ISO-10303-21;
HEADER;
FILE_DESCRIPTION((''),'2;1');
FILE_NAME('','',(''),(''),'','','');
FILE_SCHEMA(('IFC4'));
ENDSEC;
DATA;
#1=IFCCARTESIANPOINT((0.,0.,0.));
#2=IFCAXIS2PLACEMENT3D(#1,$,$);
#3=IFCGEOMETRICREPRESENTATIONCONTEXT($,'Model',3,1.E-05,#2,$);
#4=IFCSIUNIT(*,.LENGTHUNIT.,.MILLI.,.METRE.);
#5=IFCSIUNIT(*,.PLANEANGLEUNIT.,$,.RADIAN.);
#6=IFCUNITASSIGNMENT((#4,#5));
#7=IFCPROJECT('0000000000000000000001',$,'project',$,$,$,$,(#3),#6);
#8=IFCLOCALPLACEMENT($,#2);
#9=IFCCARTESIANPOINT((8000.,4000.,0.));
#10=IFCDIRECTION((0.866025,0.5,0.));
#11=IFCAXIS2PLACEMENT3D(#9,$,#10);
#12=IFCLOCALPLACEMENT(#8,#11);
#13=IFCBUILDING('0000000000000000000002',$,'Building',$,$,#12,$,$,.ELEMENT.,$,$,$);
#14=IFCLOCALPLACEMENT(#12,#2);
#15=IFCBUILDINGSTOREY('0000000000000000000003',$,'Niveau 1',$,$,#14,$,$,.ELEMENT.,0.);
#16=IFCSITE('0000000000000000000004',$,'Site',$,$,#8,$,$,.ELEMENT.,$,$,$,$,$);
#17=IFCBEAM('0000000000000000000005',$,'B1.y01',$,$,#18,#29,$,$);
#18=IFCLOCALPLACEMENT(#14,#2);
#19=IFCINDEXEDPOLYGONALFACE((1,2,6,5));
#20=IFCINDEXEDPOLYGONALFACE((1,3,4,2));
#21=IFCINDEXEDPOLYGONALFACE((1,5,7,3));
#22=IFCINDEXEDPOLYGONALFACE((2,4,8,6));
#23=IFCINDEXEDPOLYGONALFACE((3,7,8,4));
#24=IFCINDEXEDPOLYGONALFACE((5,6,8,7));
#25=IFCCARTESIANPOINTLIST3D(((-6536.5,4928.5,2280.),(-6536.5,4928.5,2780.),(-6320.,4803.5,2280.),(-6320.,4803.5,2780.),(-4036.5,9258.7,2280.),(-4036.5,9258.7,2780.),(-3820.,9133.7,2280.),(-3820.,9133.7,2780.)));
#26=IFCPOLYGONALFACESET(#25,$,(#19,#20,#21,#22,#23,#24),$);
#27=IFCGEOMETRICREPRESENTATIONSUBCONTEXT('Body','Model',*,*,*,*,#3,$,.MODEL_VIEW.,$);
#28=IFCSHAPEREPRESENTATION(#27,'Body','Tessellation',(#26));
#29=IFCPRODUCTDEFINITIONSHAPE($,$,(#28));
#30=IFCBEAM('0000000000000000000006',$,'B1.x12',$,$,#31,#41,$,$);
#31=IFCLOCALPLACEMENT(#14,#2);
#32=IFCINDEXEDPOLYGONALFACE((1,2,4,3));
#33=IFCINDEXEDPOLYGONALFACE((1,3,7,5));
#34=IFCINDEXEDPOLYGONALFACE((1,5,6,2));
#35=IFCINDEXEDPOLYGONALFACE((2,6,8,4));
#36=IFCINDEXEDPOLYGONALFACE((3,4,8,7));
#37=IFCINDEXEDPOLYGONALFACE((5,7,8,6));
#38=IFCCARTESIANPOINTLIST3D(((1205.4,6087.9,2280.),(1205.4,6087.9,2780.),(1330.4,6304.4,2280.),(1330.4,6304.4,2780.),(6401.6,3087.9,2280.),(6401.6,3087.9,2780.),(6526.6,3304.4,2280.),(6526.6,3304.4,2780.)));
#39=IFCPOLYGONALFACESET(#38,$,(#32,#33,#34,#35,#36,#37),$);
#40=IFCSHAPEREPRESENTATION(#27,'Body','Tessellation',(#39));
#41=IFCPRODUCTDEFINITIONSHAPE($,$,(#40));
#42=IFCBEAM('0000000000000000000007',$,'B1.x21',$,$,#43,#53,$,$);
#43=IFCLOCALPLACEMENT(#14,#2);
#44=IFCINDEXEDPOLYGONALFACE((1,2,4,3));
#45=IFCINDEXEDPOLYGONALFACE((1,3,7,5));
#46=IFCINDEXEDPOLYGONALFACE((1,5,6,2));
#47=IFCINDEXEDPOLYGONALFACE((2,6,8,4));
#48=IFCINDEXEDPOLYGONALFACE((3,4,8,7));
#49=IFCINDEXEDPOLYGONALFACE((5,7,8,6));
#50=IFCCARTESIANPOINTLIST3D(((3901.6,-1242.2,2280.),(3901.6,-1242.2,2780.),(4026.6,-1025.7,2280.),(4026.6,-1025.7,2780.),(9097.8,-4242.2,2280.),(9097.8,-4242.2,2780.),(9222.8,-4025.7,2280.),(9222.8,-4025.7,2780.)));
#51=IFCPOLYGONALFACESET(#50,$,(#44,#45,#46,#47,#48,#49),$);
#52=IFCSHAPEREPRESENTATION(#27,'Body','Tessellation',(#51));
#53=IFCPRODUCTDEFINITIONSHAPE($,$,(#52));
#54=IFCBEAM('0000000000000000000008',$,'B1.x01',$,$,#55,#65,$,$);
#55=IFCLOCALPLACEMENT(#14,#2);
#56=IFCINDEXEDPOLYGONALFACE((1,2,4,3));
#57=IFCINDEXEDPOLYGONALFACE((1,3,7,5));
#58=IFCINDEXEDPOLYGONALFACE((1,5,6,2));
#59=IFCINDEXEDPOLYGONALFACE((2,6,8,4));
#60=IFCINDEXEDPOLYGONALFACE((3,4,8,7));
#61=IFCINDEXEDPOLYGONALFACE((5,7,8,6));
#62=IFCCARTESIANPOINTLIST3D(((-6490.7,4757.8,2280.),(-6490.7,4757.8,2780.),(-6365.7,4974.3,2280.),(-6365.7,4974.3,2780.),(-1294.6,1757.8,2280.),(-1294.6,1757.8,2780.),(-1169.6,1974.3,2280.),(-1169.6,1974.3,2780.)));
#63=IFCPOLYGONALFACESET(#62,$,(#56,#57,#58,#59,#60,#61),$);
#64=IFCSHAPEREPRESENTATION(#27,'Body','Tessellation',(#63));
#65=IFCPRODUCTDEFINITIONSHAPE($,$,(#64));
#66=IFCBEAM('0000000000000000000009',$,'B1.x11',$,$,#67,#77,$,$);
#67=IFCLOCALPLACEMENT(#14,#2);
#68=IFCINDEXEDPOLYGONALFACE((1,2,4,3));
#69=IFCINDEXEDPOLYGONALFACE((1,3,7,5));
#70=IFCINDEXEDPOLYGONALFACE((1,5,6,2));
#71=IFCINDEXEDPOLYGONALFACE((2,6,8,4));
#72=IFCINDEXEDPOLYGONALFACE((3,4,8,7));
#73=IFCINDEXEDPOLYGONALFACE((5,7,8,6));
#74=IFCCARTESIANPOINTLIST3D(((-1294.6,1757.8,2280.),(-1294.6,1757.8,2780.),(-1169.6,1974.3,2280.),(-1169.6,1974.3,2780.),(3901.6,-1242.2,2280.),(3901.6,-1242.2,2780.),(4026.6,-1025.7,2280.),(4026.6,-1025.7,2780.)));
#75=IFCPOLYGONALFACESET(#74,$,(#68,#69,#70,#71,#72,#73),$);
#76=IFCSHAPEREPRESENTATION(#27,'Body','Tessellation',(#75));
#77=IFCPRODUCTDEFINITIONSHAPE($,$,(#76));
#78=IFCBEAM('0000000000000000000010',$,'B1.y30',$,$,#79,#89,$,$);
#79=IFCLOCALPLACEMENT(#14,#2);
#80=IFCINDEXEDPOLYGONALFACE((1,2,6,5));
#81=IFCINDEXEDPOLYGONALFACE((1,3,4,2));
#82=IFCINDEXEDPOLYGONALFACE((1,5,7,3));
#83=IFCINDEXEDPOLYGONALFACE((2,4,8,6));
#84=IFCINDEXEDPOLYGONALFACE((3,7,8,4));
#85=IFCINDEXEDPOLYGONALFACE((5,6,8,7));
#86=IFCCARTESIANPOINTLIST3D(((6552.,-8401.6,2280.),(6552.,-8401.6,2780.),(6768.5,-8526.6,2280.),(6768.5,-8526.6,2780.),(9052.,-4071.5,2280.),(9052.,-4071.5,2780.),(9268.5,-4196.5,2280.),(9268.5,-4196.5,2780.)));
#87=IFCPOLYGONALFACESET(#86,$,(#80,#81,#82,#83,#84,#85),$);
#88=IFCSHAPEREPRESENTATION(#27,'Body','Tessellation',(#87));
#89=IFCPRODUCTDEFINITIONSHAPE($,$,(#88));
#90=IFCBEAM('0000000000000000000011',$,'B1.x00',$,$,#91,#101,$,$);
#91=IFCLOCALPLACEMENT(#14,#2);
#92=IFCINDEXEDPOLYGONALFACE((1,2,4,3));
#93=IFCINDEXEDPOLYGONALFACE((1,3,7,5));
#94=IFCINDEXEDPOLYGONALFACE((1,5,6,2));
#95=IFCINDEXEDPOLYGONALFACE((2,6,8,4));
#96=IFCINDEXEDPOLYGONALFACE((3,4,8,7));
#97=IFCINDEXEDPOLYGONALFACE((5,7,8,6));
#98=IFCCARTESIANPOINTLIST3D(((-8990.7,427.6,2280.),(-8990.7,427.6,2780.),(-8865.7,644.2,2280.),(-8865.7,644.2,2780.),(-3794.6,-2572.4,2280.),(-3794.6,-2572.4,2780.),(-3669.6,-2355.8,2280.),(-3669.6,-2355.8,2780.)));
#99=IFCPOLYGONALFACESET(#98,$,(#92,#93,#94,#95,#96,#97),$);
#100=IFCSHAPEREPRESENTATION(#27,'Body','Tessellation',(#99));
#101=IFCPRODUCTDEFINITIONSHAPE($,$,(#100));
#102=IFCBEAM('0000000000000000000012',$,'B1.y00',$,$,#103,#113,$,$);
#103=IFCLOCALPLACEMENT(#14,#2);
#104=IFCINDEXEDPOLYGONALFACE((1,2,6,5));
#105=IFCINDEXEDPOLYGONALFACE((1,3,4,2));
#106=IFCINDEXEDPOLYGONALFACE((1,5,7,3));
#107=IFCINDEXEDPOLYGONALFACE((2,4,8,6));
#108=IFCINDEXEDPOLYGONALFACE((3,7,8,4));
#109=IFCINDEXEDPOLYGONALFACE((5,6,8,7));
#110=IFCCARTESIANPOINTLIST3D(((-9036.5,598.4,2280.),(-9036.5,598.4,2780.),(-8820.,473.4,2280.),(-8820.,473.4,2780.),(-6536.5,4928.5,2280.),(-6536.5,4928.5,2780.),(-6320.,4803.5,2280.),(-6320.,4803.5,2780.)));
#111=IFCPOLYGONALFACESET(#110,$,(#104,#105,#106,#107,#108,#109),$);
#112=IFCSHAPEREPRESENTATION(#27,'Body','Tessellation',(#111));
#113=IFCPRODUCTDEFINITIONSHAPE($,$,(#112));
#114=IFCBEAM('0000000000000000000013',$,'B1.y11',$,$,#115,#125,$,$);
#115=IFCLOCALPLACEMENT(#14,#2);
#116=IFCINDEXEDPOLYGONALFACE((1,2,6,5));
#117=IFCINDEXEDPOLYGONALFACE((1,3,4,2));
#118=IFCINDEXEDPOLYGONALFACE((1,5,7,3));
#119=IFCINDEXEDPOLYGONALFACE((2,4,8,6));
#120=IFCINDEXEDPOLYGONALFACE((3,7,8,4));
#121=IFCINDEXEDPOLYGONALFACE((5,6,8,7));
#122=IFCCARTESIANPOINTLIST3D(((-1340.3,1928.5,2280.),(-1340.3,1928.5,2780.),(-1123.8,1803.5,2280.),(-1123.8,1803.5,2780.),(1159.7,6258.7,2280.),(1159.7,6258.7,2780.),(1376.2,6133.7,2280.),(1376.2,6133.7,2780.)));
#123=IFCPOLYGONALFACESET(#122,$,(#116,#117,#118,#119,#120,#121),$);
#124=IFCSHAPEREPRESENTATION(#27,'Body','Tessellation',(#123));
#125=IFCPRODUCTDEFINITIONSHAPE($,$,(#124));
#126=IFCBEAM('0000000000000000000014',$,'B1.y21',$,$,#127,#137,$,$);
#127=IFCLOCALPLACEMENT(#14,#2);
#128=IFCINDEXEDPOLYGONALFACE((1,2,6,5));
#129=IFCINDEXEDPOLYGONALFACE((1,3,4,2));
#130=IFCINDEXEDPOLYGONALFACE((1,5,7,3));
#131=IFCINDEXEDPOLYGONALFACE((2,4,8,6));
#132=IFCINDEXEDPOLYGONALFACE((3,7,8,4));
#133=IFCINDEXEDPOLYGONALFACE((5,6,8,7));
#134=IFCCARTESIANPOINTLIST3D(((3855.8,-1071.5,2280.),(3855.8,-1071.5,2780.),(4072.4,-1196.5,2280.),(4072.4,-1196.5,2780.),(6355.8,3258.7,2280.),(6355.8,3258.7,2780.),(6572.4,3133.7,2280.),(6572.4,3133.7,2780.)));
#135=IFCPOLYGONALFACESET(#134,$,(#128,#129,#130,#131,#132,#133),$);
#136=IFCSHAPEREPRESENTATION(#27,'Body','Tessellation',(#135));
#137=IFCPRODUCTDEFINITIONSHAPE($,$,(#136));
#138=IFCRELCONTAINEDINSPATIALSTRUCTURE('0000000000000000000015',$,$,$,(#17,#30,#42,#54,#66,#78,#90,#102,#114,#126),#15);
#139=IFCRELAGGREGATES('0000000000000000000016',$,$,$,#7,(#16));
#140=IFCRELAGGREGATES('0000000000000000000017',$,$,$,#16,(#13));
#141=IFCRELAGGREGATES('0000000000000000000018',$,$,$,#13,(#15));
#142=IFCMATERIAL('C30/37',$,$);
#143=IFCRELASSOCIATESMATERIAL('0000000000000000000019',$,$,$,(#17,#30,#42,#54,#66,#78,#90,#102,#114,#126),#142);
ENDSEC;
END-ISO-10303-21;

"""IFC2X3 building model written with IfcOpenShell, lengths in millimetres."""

from ifc_helpers import new_model, si_unit, frame, origin, origin_2d, place, context, subcontext, project, spatial, rectangle, extrude, material, element, save


model = new_model("IFC2X3")

# Units and contexts
model_context = context("Model", 3, precision=1e-05, world=origin())
body_context = subcontext(model_context, "Body", "Model", "MODEL_VIEW")
ifc_project = project(units=[si_unit("LENGTHUNIT", "METRE", prefix="MILLI"), si_unit("PLANEANGLEUNIT", "RADIAN")], contexts=[model_context])

# Site, building, storey
site_placement = place(None, origin())
site = spatial("IfcSite", under=ifc_project, at=site_placement, Name="Site", CompositionType="ELEMENT")
building_placement = place(site_placement, frame((8000.0, 4000.0, 0.0), x_axis=(0.866025, 0.5, 0.0)))
building = spatial("IfcBuilding", under=site, at=building_placement, Name="Building", CompositionType="ELEMENT")
storey_placement = place(building_placement, origin())
storey = spatial("IfcBuildingStorey", under=building, at=storey_placement, Name="Niveau 1", CompositionType="ELEMENT", Elevation=0.0)

# Shared definitions
ifc_material = material(Name="C30/37")

# Beams
beam_1_placement = place(storey_placement, frame((-6428.2, 4866.0, 2530.0), z_axis=(0.5, 0.866025, 0.0), x_axis=(-0.866025, 0.5, 0.0)))
element("IfcBeam", 1, at=beam_1_placement, inside=storey, material=ifc_material, Name="B1.y01", context=body_context, shape_type="SweptSolid", body=[
    extrude(rectangle(XDim=250.0, YDim=500.0, at=origin_2d()), origin(), (0.0, 0.0, 1.0), 5000.0),
])
for number, where, z_axis, x_axis, name in (
    (2, (1267.9, 6196.2, 2530.0), (0.866025, -0.5, 0.0), (0.5, 0.866025, 0.0), "B1.x12"),
    (3, (3964.1, -1134.0, 2530.0), (0.866025, -0.5, 0.0), (0.5, 0.866025, 0.0), "B1.x21"),
    (4, (-6428.2, 4866.0, 2530.0), (0.866025, -0.5, 0.0), (0.5, 0.866025, 0.0), "B1.x01"),
    (5, (-1232.1, 1866.0, 2530.0), (0.866025, -0.5, 0.0), (0.5, 0.866025, 0.0), "B1.x11"),
):
    element("IfcBeam", number, at=place(storey_placement, frame(where, z_axis=z_axis, x_axis=x_axis)), inside=storey, material=ifc_material, Name=name, context=body_context, shape_type="SweptSolid", body=[
        extrude(rectangle(XDim=250.0, YDim=500.0, at=origin_2d()), origin(), (0.0, 0.0, 1.0), 6000.0),
    ])
beam_2_placement = place(storey_placement, frame((6660.3, -8464.1, 2530.0), z_axis=(0.5, 0.866025, 0.0), x_axis=(-0.866025, 0.5, 0.0)))
element("IfcBeam", 6, at=beam_2_placement, inside=storey, material=ifc_material, Name="B1.y30", context=body_context, shape_type="SweptSolid", body=[
    extrude(rectangle(XDim=250.0, YDim=500.0, at=origin_2d()), origin(), (0.0, 0.0, 1.0), 5000.0),
])
beam_3_placement = place(storey_placement, frame((-8928.2, 535.9, 2530.0), z_axis=(0.866025, -0.5, 0.0), x_axis=(0.5, 0.866025, 0.0)))
element("IfcBeam", 7, at=beam_3_placement, inside=storey, material=ifc_material, Name="B1.x00", context=body_context, shape_type="SweptSolid", body=[
    extrude(rectangle(XDim=250.0, YDim=500.0, at=origin_2d()), origin(), (0.0, 0.0, 1.0), 6000.0),
])
for number, where, z_axis, x_axis, name in (
    (8, (-8928.2, 535.9, 2530.0), (0.5, 0.866025, 0.0), (-0.866025, 0.5, 0.0), "B1.y00"),
    (9, (-1232.1, 1866.0, 2530.0), (0.5, 0.866025, 0.0), (-0.866025, 0.5, 0.0), "B1.y11"),
    (10, (3964.1, -1134.0, 2530.0), (0.5, 0.866025, 0.0), (-0.866025, 0.5, 0.0), "B1.y21"),
):
    element("IfcBeam", number, at=place(storey_placement, frame(where, z_axis=z_axis, x_axis=x_axis)), inside=storey, material=ifc_material, Name=name, context=body_context, shape_type="SweptSolid", body=[
        extrude(rectangle(XDim=250.0, YDim=500.0, at=origin_2d()), origin(), (0.0, 0.0, 1.0), 5000.0),
    ])

save(model, "model.ifc")
